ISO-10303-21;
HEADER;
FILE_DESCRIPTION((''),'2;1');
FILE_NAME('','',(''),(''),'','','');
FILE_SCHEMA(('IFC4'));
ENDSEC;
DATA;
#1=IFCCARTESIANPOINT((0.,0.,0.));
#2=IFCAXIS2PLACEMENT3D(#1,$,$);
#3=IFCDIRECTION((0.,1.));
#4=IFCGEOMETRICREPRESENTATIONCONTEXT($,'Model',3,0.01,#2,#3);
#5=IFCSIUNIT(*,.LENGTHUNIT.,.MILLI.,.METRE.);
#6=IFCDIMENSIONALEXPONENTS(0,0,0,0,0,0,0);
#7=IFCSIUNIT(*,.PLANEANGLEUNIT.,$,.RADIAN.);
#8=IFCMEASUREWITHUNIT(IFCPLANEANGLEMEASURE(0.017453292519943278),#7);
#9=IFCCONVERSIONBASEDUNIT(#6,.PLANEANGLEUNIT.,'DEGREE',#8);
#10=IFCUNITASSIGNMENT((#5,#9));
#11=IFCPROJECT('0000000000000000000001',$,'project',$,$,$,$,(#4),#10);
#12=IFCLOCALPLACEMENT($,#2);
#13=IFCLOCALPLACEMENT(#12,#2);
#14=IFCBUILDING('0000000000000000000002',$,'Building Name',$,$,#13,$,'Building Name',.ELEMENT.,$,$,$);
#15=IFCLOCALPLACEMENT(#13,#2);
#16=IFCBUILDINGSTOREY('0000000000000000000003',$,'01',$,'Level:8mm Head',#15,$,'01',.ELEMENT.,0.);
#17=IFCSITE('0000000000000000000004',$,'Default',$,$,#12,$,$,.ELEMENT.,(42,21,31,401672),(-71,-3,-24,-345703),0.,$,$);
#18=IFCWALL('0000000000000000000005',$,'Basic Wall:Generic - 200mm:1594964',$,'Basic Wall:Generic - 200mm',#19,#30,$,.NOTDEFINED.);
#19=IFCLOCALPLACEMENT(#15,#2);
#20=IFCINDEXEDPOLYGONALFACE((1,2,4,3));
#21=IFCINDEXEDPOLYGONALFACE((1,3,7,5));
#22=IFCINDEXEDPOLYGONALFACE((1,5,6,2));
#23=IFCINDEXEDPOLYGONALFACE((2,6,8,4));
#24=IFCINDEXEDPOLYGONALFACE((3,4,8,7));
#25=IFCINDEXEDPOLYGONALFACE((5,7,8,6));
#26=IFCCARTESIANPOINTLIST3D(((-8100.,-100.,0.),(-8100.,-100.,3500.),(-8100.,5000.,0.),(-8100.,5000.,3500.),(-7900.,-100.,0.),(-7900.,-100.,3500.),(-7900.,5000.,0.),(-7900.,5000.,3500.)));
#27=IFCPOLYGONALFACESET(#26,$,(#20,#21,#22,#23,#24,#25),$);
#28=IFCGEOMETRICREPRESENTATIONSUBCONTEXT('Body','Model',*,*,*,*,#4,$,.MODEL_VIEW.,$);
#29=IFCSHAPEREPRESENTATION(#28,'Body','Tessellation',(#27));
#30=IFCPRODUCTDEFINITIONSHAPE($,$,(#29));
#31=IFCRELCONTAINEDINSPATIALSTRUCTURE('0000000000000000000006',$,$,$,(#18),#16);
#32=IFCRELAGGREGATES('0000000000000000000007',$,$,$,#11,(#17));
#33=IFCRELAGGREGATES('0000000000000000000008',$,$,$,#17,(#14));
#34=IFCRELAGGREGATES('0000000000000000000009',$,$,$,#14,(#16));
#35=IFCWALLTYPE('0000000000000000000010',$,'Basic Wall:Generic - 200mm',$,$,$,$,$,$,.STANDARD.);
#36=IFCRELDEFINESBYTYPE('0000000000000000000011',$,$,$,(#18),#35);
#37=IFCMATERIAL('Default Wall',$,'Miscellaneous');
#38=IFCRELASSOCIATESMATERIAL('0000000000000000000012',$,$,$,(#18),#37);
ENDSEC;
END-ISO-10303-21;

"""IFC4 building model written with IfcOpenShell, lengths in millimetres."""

from ifc_helpers import new_model, entity, si_unit, converted_unit, direction, frame, origin, place, context, subcontext, project, spatial, indexed_curve, outline, extrude, material, type_object, element, save


model = new_model("IFC4")

# Units and contexts
model_context = context("Model", 3, precision=0.01, world=origin(), true_north=direction((0.0, 1.0)))
body_context = subcontext(model_context, "Body", "Model", "MODEL_VIEW")
ifc_project = project(units=[si_unit("LENGTHUNIT", "METRE", prefix="MILLI"), converted_unit("PLANEANGLEUNIT", "DEGREE", entity("IfcPlaneAngleMeasure", 0.017453292519943278), si_unit("PLANEANGLEUNIT", "RADIAN"), dimensions=[0, 0, 0, 0, 0, 0, 0])], contexts=[model_context])

# Site, building, storey
site_placement = place(None, origin())
site = spatial("IfcSite", under=ifc_project, at=site_placement, Name="Default", CompositionType="ELEMENT", RefLatitude=(42, 21, 31, 401672), RefLongitude=(-71, -3, -24, -345703), RefElevation=0.0)
building_placement = place(site_placement, origin())
building = spatial("IfcBuilding", under=site, at=building_placement, Name="Building Name", LongName="Building Name", CompositionType="ELEMENT")
storey_placement = place(building_placement, origin())
storey = spatial("IfcBuildingStorey", under=building, at=storey_placement, Name="01", ObjectType="Level:8mm Head", LongName="01", CompositionType="ELEMENT", Elevation=0.0)

# Wall
ifc_material_1 = material(Name="Default Wall", Category="Miscellaneous")
wall_type = type_object("IfcWallType", Name="Basic Wall:Generic - 200mm", PredefinedType="STANDARD")
wall_placement = place(storey_placement, frame((-8000.0, -100.0, 0.0), z_axis=(0.0, 0.0, 1.0), x_axis=(0.0, 1.0, 0.0)))
element("IfcWall", 1, at=wall_placement, inside=storey, type_object=wall_type, material=ifc_material_1, Name="Basic Wall:Generic - 200mm:1594964", ObjectType="Basic Wall:Generic - 200mm", PredefinedType="NOTDEFINED", context=body_context, shape_type="SweptSolid", body=[
    extrude(outline(indexed_curve([(5100.0, 100.0), (0.0, 100.0), (0.0, -100.0), (5100.0, -100.0), (5100.0, 100.0)], self_intersect=False)), origin(), (0.0, 0.0, 1.0), 3500.0),
])

save(model, "model.ifc")
